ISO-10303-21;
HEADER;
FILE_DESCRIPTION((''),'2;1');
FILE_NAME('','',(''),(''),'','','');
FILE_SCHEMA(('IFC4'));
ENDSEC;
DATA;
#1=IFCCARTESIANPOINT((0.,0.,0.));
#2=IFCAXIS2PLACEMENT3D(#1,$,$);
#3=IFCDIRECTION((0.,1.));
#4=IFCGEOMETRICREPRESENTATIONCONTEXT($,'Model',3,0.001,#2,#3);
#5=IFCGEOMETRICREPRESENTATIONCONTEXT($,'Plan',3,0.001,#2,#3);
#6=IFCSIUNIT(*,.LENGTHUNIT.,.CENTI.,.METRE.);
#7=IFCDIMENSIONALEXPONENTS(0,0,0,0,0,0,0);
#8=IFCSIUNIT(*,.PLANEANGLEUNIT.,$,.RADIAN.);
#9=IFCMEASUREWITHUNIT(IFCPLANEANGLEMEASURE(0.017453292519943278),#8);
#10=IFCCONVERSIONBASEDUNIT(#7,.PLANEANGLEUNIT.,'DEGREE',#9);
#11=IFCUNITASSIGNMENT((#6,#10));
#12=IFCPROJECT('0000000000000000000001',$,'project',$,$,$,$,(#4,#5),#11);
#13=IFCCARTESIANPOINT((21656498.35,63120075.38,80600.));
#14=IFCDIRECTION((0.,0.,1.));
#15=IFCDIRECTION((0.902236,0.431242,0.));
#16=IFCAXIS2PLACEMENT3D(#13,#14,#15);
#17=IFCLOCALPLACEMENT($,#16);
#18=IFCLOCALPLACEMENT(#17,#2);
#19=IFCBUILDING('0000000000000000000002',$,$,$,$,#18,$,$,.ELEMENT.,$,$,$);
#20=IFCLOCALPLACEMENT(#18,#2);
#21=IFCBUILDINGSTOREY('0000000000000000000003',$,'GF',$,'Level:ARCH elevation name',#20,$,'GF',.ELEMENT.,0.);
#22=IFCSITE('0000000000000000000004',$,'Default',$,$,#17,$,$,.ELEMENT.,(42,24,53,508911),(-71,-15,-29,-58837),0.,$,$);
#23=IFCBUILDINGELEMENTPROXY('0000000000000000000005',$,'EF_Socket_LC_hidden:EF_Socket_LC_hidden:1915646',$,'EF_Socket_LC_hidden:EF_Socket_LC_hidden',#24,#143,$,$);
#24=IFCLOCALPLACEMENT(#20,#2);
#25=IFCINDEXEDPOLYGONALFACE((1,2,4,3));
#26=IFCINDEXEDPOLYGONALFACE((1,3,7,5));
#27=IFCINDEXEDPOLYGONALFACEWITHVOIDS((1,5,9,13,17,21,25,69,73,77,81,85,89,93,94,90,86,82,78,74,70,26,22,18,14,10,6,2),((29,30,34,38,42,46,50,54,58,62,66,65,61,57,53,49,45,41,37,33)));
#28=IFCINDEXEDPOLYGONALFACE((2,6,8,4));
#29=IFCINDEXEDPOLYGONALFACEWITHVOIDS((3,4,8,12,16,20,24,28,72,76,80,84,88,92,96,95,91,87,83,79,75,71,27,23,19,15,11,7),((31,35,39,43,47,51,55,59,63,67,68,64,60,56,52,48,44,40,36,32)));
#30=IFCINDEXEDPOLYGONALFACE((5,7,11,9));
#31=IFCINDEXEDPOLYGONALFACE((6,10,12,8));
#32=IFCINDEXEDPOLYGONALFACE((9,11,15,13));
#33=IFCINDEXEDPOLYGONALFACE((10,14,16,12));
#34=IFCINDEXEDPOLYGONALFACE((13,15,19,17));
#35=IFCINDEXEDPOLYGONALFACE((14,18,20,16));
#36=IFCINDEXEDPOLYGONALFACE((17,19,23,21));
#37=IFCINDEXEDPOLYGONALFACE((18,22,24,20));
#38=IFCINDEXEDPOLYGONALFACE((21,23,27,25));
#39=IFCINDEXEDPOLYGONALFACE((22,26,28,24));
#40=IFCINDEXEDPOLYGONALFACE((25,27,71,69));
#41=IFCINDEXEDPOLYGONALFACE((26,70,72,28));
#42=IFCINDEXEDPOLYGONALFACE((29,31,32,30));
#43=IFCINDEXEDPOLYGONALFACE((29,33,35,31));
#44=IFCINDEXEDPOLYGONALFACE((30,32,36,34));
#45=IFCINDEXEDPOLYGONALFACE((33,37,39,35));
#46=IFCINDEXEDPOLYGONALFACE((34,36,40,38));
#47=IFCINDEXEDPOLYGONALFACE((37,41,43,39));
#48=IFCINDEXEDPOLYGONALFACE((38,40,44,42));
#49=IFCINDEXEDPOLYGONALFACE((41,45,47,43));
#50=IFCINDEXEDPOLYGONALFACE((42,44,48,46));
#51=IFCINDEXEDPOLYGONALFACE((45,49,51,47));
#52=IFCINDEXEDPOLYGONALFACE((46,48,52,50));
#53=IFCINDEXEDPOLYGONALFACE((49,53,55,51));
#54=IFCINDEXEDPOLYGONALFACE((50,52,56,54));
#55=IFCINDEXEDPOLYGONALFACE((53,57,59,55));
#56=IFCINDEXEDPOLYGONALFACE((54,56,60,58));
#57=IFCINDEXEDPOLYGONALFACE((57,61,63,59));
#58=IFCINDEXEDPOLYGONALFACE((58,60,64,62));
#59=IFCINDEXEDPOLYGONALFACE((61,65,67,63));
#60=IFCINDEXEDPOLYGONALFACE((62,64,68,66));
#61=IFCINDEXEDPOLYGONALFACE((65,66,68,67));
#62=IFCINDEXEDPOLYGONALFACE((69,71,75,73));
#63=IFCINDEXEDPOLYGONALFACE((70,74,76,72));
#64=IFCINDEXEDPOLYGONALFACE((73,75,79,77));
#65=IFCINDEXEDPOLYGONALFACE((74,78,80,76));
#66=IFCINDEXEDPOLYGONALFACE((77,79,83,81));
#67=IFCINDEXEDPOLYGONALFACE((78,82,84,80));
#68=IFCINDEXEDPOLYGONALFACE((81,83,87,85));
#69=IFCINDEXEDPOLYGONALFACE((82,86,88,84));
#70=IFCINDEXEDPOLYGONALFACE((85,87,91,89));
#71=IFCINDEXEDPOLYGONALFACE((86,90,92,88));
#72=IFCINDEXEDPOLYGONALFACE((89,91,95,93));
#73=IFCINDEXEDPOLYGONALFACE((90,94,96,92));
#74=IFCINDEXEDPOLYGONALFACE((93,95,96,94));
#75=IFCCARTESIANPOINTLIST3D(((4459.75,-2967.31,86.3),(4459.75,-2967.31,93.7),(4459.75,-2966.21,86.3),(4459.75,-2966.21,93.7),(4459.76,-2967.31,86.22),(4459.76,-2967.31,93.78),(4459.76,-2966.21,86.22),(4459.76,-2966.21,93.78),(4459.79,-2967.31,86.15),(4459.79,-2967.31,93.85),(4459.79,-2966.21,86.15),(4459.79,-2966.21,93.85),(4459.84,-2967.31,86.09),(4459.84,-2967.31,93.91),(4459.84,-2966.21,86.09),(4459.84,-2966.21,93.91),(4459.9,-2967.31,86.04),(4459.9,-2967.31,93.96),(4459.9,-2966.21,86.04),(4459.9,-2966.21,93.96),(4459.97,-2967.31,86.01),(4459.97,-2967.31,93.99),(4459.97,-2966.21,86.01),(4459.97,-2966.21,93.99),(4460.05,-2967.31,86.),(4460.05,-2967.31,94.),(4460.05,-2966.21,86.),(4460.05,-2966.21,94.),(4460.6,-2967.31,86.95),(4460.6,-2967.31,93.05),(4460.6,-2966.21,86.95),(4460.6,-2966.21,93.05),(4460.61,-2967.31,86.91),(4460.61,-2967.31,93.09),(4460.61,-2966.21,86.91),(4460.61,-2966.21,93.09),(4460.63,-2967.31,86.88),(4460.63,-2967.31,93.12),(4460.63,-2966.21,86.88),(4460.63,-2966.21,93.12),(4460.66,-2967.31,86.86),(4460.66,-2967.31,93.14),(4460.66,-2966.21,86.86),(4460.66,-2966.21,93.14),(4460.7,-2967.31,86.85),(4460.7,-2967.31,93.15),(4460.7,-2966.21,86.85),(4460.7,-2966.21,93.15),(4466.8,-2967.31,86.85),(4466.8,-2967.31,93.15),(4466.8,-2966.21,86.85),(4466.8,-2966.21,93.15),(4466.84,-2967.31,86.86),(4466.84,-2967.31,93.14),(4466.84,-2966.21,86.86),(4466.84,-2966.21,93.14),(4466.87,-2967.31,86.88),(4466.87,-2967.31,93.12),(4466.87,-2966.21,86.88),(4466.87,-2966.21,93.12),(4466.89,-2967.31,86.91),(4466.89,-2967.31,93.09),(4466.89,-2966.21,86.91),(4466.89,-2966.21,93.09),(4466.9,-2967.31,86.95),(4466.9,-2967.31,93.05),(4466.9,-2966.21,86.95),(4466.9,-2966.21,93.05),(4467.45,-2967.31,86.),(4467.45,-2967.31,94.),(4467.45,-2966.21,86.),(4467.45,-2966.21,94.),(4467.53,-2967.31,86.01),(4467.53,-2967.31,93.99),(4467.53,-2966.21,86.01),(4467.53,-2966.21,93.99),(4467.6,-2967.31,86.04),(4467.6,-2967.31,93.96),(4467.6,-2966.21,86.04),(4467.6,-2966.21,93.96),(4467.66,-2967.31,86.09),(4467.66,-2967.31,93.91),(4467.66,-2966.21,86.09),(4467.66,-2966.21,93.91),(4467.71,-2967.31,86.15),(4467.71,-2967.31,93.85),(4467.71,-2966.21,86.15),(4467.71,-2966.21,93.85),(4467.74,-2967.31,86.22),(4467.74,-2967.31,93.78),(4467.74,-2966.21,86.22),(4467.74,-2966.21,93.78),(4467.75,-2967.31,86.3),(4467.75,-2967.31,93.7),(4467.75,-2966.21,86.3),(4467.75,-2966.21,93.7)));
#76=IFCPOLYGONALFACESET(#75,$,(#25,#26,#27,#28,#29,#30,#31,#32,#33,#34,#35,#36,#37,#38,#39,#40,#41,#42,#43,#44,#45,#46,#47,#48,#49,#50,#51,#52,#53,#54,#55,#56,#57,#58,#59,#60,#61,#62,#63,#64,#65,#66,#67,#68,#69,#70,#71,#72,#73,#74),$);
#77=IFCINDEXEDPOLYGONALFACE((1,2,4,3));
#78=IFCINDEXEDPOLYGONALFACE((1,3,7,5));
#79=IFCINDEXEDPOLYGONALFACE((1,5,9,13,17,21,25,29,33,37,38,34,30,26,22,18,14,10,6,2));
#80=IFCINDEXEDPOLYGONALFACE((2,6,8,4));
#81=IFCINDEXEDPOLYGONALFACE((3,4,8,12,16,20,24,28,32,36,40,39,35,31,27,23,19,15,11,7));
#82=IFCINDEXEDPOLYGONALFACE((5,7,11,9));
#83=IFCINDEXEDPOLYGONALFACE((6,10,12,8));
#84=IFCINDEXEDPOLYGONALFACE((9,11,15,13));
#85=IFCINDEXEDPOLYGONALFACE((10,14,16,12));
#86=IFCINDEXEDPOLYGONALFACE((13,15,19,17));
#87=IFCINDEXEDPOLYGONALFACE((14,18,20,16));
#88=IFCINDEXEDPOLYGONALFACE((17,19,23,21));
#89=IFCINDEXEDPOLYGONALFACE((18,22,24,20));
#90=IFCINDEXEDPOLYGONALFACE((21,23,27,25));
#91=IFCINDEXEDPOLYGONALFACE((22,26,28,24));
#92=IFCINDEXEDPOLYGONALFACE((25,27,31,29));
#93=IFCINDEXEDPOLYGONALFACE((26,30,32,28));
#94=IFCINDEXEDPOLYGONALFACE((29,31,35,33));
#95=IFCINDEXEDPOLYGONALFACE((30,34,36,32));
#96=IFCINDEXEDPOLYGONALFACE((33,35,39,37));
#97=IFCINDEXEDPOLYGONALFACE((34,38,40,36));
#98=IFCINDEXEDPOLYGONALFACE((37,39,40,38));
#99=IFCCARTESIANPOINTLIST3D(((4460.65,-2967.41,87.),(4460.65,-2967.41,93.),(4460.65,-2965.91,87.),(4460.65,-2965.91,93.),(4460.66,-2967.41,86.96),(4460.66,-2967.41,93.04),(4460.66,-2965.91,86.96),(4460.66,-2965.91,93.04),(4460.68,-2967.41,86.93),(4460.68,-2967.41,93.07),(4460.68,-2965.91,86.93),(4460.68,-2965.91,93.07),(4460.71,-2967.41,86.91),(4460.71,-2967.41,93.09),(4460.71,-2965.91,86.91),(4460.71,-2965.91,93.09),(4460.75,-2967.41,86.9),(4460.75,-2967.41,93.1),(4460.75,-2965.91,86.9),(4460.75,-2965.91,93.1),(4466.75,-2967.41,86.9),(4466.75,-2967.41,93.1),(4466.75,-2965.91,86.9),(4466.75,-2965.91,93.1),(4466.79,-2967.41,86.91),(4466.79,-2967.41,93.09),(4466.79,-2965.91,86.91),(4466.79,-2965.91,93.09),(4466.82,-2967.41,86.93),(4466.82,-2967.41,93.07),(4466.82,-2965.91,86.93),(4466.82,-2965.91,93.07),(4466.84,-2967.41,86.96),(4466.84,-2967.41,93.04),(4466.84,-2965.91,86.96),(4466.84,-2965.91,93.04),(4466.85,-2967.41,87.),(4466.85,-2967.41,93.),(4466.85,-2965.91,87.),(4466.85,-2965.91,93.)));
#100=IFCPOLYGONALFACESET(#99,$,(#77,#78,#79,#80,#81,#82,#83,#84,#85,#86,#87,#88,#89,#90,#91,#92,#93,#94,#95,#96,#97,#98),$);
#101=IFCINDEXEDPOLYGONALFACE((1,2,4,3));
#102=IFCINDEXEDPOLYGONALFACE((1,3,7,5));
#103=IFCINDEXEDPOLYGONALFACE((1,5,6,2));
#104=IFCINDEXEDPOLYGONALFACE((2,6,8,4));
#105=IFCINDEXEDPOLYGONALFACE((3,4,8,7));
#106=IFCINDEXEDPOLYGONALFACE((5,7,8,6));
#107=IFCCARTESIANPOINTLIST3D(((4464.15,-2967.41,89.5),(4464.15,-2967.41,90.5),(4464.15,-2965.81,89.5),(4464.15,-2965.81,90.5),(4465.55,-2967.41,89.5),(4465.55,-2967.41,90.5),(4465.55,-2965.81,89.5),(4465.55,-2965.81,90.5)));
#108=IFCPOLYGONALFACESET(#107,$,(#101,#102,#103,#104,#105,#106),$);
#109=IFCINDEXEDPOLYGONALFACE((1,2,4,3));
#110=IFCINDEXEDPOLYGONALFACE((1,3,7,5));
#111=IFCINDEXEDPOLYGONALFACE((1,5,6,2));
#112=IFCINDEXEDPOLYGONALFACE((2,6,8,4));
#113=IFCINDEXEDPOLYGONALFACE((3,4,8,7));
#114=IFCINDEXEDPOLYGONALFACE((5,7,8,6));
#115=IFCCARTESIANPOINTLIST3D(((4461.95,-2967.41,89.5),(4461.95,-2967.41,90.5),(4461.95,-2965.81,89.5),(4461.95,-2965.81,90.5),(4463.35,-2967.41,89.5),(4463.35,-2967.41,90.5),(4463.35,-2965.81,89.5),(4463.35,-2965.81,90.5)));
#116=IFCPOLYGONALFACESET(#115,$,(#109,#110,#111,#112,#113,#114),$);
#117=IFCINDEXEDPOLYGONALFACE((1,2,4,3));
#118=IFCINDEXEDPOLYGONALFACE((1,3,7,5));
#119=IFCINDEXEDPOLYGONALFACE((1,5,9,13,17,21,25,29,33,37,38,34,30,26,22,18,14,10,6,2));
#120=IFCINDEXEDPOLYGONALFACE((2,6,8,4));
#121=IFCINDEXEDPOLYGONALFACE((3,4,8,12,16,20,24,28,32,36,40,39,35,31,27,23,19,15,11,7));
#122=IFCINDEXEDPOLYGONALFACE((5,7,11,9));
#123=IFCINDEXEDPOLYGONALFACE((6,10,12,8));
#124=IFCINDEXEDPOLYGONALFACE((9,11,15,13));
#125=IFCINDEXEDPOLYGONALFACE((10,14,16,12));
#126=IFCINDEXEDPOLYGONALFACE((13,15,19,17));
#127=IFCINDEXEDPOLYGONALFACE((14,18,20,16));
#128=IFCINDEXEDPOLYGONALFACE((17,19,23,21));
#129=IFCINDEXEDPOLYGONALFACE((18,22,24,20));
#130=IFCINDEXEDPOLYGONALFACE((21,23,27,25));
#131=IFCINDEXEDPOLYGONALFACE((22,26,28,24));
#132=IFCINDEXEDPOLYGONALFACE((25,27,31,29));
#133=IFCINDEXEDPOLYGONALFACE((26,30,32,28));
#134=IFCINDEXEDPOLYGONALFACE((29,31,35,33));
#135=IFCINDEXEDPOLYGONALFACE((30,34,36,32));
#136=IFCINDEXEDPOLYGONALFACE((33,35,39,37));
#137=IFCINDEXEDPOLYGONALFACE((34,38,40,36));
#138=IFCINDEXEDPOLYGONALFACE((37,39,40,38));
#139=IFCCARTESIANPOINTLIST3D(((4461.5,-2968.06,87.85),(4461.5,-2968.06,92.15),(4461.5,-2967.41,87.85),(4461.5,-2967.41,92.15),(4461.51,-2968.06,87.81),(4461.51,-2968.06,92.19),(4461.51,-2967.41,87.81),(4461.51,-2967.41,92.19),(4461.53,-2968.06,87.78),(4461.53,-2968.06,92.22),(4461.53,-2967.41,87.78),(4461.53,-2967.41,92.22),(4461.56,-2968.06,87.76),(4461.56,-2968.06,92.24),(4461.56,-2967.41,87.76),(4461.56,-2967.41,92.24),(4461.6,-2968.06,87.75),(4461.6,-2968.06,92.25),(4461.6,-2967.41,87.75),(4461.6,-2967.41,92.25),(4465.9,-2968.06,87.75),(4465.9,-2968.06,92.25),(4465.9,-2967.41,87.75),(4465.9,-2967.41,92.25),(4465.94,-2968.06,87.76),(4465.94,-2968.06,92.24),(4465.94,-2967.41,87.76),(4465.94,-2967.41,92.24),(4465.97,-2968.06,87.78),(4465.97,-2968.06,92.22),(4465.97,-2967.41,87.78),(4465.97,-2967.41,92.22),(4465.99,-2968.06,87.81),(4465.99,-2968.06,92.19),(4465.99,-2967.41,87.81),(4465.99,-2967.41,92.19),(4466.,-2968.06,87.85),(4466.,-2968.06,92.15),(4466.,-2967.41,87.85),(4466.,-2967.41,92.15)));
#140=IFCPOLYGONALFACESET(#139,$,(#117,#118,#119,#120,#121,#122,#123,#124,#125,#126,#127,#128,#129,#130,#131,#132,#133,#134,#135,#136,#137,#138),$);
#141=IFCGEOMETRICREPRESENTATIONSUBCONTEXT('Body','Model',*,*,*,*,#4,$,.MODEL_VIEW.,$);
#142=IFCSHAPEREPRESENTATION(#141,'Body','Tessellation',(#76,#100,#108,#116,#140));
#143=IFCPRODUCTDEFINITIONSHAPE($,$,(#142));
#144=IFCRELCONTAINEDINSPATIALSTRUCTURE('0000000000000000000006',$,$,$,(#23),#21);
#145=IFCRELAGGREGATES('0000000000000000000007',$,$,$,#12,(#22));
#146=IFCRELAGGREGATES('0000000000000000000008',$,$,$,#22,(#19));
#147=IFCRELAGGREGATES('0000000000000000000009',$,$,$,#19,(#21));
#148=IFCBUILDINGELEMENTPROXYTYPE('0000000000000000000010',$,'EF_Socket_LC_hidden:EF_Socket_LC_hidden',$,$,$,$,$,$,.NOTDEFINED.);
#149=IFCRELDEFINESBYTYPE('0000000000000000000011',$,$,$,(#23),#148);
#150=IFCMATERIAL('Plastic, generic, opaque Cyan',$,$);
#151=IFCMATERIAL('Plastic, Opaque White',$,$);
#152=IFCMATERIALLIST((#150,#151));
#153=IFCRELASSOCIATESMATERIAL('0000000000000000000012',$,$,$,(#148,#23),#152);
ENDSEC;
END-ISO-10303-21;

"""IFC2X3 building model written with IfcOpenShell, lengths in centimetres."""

from ifc_helpers import new_model, entity, si_unit, converted_unit, direction, frame, frame_2d, origin, place, context, subcontext, project, spatial, polyline, circle_curve, parameter, trimmed, segment, composite_curve, rectangle, outline, extrude, source, transform, mapped, material, material_list, type_object, type_shapes, element, save


model = new_model("IFC2X3")

# Units and contexts
model_context = context("Model", 3, precision=0.001, world=origin(), true_north=direction((0.0, 1.0)))
plan_context = context("Plan", 3, precision=0.001, world=origin(), true_north=direction((0.0, 1.0)))
body_context = subcontext(model_context, "Body", "Model", "MODEL_VIEW")
ifc_project = project(units=[si_unit("LENGTHUNIT", "METRE", prefix="CENTI"), converted_unit("PLANEANGLEUNIT", "DEGREE", entity("IfcPlaneAngleMeasure", 0.017453292519943278), si_unit("PLANEANGLEUNIT", "RADIAN"), dimensions=[0, 0, 0, 0, 0, 0, 0])], contexts=[model_context, plan_context])

# Site, building, storey
site_placement = place(None, frame((21656498.35, 63120075.38, 80600.0), z_axis=(0.0, 0.0, 1.0), x_axis=(0.902236, 0.431242, 0.0)))
site = spatial("IfcSite", under=ifc_project, at=site_placement, Name="Default", CompositionType="ELEMENT", RefLatitude=(42, 24, 53, 508911), RefLongitude=(-71, -15, -29, -58837), RefElevation=0.0)
building_placement = place(site_placement, origin())
building = spatial("IfcBuilding", under=site, at=building_placement, CompositionType="ELEMENT")
storey_placement = place(building_placement, origin())
storey = spatial("IfcBuildingStorey", under=building, at=storey_placement, Name="GF", ObjectType="Level:ARCH elevation name", LongName="GF", CompositionType="ELEMENT", Elevation=0.0)

# Building element proxy
ifc_material_1 = material(Name="Plastic, generic, opaque Cyan")
ifc_material_2 = material(Name="Plastic, Opaque White")
ifc_material_list_1 = material_list([ifc_material_1, ifc_material_2])
building_element_proxy_type_1 = type_object("IfcBuildingElementProxyType", Name="EF_Socket_LC_hidden:EF_Socket_LC_hidden", PredefinedType="NOTDEFINED", material=ifc_material_list_1)
shared_shape_1 = source(origin(), body_context, "Body", "SweptSolid", [
    extrude(outline(composite_curve([segment(trimmed(circle_curve(frame_2d((3.7, -3.7), x_axis=(1.0, 0.0)), 0.3), [parameter(270.0)], [parameter(0.0)], True, "PARAMETER"), True, "CONTINUOUS"), segment(polyline([(4.0, -3.7), (4.0, 3.7)]), True, "CONTINUOUS"), segment(trimmed(circle_curve(frame_2d((3.7, 3.7), x_axis=(1.0, 0.0)), 0.3), [parameter(0.0)], [parameter(90.0)], True, "PARAMETER"), True, "CONTINUOUS"), segment(polyline([(3.7, 4.0), (-3.7, 4.0)]), True, "CONTINUOUS"), segment(trimmed(circle_curve(frame_2d((-3.7, 3.7), x_axis=(1.0, 0.0)), 0.3), [parameter(90.0)], [parameter(180.0)], True, "PARAMETER"), True, "CONTINUOUS"), segment(polyline([(-4.0, 3.7), (-4.0, -3.7)]), True, "CONTINUOUS"), segment(trimmed(circle_curve(frame_2d((-3.7, -3.7), x_axis=(1.0, 0.0)), 0.3), [parameter(180.0)], [parameter(270.0)], True, "PARAMETER"), True, "CONTINUOUS"), segment(polyline([(-3.7, -4.0), (3.7, -4.0)]), True, "CONTINUOUS")], self_intersect=False), holes=[composite_curve([segment(polyline([(-3.15, -3.05), (-3.15, 3.05)]), True, "CONTINUOUS"), segment(trimmed(circle_curve(frame_2d((-3.05, 3.05), x_axis=(1.0, 0.0)), 0.1), [parameter(90.0)], [parameter(180.0)], True, "PARAMETER"), False, "CONTINUOUS"), segment(polyline([(-3.05, 3.15), (3.05, 3.15)]), True, "CONTINUOUS"), segment(trimmed(circle_curve(frame_2d((3.05, 3.05), x_axis=(1.0, 0.0)), 0.1), [parameter(360.0)], [parameter(90.0)], True, "PARAMETER"), False, "CONTINUOUS"), segment(polyline([(3.15, 3.05), (3.15, -3.05)]), True, "CONTINUOUS"), segment(trimmed(circle_curve(frame_2d((3.05, -3.05), x_axis=(1.0, 0.0)), 0.1), [parameter(270.0)], [parameter(360.0)], True, "PARAMETER"), False, "CONTINUOUS"), segment(polyline([(3.05, -3.15), (-3.05, -3.15)]), True, "CONTINUOUS"), segment(trimmed(circle_curve(frame_2d((-3.05, -3.05), x_axis=(1.0, 0.0)), 0.1), [parameter(180.0)], [parameter(270.0)], True, "PARAMETER"), False, "CONTINUOUS")], self_intersect=False)]), frame((0.0, 0.0, 0.0), z_axis=(0.0, 1.0, 0.0), x_axis=(1.0, 0.0, 0.0)), (0.0, 0.0, 1.0), 1.1),
    extrude(outline(composite_curve([segment(trimmed(circle_curve(frame_2d((3.0, -3.0), x_axis=(1.0, 0.0)), 0.1), [parameter(270.0)], [parameter(0.0)], True, "PARAMETER"), True, "CONTINUOUS"), segment(polyline([(3.1, -3.0), (3.1, 3.0)]), True, "CONTINUOUS"), segment(trimmed(circle_curve(frame_2d((3.0, 3.0), x_axis=(1.0, 0.0)), 0.1), [parameter(0.0)], [parameter(90.0)], True, "PARAMETER"), True, "CONTINUOUS"), segment(polyline([(3.0, 3.1), (-3.0, 3.1)]), True, "CONTINUOUS"), segment(trimmed(circle_curve(frame_2d((-3.0, 3.0), x_axis=(1.0, 0.0)), 0.1), [parameter(90.0)], [parameter(180.0)], True, "PARAMETER"), True, "CONTINUOUS"), segment(polyline([(-3.1, 3.0), (-3.1, -3.0)]), True, "CONTINUOUS"), segment(trimmed(circle_curve(frame_2d((-3.0, -3.0), x_axis=(1.0, 0.0)), 0.1), [parameter(180.0)], [parameter(270.0)], True, "PARAMETER"), True, "CONTINUOUS"), segment(polyline([(-3.0, -3.1), (3.0, -3.1)]), True, "CONTINUOUS")], self_intersect=False)), frame((0.0, -0.1, 0.0), z_axis=(0.0, 1.0, 0.0), x_axis=(1.0, 0.0, 0.0)), (0.0, 0.0, 1.0), 1.5),
    extrude(rectangle(XDim=1.6, YDim=1.4, at=frame_2d((0.0, 0.0), x_axis=(1.0, 0.0))), frame((1.1, 0.7, -0.5), z_axis=(0.0, 0.0, 1.0), x_axis=(0.0, -1.0, 0.0)), (0.0, 0.0, 1.0), 1.0),
    extrude(rectangle(XDim=1.6, YDim=1.4, at=frame_2d((0.0, 0.0), x_axis=(1.0, 0.0))), frame((-1.1, 0.7, -0.5), z_axis=(0.0, 0.0, 1.0), x_axis=(0.0, -1.0, 0.0)), (0.0, 0.0, 1.0), 1.0),
    extrude(outline(composite_curve([segment(trimmed(circle_curve(frame_2d((2.15, -2.15), x_axis=(1.0, 0.0)), 0.1), [parameter(270.0)], [parameter(0.0)], True, "PARAMETER"), True, "CONTINUOUS"), segment(polyline([(2.25, -2.15), (2.25, 2.15)]), True, "CONTINUOUS"), segment(trimmed(circle_curve(frame_2d((2.15, 2.15), x_axis=(1.0, 0.0)), 0.1), [parameter(0.0)], [parameter(90.0)], True, "PARAMETER"), True, "CONTINUOUS"), segment(polyline([(2.15, 2.25), (-2.15, 2.25)]), True, "CONTINUOUS"), segment(trimmed(circle_curve(frame_2d((-2.15, 2.15), x_axis=(1.0, 0.0)), 0.1), [parameter(90.0)], [parameter(180.0)], True, "PARAMETER"), True, "CONTINUOUS"), segment(polyline([(-2.25, 2.15), (-2.25, -2.15)]), True, "CONTINUOUS"), segment(trimmed(circle_curve(frame_2d((-2.15, -2.15), x_axis=(1.0, 0.0)), 0.1), [parameter(180.0)], [parameter(270.0)], True, "PARAMETER"), True, "CONTINUOUS"), segment(polyline([(-2.15, -2.25), (2.15, -2.25)]), True, "CONTINUOUS")], self_intersect=False)), frame((0.0, -0.75, 0.0), z_axis=(0.0, 1.0, 0.0), x_axis=(1.0, 0.0, 0.0)), (0.0, 0.0, 1.0), 0.65),
])
type_shapes(building_element_proxy_type_1, [shared_shape_1])
proxy_1_placement = place(storey_placement, frame((4463.75, -2967.31, 90.0)))
element("IfcBuildingElementProxy", 1, at=proxy_1_placement, inside=storey, type_object=building_element_proxy_type_1, material=ifc_material_list_1, Name="EF_Socket_LC_hidden:EF_Socket_LC_hidden:1915646", ObjectType="EF_Socket_LC_hidden:EF_Socket_LC_hidden", context=body_context, shape_type="MappedRepresentation", body=[
    mapped(shared_shape_1, transform((0.0, 0.0, 0.0), scale=1.0)),
])

save(model, "model.ifc")
